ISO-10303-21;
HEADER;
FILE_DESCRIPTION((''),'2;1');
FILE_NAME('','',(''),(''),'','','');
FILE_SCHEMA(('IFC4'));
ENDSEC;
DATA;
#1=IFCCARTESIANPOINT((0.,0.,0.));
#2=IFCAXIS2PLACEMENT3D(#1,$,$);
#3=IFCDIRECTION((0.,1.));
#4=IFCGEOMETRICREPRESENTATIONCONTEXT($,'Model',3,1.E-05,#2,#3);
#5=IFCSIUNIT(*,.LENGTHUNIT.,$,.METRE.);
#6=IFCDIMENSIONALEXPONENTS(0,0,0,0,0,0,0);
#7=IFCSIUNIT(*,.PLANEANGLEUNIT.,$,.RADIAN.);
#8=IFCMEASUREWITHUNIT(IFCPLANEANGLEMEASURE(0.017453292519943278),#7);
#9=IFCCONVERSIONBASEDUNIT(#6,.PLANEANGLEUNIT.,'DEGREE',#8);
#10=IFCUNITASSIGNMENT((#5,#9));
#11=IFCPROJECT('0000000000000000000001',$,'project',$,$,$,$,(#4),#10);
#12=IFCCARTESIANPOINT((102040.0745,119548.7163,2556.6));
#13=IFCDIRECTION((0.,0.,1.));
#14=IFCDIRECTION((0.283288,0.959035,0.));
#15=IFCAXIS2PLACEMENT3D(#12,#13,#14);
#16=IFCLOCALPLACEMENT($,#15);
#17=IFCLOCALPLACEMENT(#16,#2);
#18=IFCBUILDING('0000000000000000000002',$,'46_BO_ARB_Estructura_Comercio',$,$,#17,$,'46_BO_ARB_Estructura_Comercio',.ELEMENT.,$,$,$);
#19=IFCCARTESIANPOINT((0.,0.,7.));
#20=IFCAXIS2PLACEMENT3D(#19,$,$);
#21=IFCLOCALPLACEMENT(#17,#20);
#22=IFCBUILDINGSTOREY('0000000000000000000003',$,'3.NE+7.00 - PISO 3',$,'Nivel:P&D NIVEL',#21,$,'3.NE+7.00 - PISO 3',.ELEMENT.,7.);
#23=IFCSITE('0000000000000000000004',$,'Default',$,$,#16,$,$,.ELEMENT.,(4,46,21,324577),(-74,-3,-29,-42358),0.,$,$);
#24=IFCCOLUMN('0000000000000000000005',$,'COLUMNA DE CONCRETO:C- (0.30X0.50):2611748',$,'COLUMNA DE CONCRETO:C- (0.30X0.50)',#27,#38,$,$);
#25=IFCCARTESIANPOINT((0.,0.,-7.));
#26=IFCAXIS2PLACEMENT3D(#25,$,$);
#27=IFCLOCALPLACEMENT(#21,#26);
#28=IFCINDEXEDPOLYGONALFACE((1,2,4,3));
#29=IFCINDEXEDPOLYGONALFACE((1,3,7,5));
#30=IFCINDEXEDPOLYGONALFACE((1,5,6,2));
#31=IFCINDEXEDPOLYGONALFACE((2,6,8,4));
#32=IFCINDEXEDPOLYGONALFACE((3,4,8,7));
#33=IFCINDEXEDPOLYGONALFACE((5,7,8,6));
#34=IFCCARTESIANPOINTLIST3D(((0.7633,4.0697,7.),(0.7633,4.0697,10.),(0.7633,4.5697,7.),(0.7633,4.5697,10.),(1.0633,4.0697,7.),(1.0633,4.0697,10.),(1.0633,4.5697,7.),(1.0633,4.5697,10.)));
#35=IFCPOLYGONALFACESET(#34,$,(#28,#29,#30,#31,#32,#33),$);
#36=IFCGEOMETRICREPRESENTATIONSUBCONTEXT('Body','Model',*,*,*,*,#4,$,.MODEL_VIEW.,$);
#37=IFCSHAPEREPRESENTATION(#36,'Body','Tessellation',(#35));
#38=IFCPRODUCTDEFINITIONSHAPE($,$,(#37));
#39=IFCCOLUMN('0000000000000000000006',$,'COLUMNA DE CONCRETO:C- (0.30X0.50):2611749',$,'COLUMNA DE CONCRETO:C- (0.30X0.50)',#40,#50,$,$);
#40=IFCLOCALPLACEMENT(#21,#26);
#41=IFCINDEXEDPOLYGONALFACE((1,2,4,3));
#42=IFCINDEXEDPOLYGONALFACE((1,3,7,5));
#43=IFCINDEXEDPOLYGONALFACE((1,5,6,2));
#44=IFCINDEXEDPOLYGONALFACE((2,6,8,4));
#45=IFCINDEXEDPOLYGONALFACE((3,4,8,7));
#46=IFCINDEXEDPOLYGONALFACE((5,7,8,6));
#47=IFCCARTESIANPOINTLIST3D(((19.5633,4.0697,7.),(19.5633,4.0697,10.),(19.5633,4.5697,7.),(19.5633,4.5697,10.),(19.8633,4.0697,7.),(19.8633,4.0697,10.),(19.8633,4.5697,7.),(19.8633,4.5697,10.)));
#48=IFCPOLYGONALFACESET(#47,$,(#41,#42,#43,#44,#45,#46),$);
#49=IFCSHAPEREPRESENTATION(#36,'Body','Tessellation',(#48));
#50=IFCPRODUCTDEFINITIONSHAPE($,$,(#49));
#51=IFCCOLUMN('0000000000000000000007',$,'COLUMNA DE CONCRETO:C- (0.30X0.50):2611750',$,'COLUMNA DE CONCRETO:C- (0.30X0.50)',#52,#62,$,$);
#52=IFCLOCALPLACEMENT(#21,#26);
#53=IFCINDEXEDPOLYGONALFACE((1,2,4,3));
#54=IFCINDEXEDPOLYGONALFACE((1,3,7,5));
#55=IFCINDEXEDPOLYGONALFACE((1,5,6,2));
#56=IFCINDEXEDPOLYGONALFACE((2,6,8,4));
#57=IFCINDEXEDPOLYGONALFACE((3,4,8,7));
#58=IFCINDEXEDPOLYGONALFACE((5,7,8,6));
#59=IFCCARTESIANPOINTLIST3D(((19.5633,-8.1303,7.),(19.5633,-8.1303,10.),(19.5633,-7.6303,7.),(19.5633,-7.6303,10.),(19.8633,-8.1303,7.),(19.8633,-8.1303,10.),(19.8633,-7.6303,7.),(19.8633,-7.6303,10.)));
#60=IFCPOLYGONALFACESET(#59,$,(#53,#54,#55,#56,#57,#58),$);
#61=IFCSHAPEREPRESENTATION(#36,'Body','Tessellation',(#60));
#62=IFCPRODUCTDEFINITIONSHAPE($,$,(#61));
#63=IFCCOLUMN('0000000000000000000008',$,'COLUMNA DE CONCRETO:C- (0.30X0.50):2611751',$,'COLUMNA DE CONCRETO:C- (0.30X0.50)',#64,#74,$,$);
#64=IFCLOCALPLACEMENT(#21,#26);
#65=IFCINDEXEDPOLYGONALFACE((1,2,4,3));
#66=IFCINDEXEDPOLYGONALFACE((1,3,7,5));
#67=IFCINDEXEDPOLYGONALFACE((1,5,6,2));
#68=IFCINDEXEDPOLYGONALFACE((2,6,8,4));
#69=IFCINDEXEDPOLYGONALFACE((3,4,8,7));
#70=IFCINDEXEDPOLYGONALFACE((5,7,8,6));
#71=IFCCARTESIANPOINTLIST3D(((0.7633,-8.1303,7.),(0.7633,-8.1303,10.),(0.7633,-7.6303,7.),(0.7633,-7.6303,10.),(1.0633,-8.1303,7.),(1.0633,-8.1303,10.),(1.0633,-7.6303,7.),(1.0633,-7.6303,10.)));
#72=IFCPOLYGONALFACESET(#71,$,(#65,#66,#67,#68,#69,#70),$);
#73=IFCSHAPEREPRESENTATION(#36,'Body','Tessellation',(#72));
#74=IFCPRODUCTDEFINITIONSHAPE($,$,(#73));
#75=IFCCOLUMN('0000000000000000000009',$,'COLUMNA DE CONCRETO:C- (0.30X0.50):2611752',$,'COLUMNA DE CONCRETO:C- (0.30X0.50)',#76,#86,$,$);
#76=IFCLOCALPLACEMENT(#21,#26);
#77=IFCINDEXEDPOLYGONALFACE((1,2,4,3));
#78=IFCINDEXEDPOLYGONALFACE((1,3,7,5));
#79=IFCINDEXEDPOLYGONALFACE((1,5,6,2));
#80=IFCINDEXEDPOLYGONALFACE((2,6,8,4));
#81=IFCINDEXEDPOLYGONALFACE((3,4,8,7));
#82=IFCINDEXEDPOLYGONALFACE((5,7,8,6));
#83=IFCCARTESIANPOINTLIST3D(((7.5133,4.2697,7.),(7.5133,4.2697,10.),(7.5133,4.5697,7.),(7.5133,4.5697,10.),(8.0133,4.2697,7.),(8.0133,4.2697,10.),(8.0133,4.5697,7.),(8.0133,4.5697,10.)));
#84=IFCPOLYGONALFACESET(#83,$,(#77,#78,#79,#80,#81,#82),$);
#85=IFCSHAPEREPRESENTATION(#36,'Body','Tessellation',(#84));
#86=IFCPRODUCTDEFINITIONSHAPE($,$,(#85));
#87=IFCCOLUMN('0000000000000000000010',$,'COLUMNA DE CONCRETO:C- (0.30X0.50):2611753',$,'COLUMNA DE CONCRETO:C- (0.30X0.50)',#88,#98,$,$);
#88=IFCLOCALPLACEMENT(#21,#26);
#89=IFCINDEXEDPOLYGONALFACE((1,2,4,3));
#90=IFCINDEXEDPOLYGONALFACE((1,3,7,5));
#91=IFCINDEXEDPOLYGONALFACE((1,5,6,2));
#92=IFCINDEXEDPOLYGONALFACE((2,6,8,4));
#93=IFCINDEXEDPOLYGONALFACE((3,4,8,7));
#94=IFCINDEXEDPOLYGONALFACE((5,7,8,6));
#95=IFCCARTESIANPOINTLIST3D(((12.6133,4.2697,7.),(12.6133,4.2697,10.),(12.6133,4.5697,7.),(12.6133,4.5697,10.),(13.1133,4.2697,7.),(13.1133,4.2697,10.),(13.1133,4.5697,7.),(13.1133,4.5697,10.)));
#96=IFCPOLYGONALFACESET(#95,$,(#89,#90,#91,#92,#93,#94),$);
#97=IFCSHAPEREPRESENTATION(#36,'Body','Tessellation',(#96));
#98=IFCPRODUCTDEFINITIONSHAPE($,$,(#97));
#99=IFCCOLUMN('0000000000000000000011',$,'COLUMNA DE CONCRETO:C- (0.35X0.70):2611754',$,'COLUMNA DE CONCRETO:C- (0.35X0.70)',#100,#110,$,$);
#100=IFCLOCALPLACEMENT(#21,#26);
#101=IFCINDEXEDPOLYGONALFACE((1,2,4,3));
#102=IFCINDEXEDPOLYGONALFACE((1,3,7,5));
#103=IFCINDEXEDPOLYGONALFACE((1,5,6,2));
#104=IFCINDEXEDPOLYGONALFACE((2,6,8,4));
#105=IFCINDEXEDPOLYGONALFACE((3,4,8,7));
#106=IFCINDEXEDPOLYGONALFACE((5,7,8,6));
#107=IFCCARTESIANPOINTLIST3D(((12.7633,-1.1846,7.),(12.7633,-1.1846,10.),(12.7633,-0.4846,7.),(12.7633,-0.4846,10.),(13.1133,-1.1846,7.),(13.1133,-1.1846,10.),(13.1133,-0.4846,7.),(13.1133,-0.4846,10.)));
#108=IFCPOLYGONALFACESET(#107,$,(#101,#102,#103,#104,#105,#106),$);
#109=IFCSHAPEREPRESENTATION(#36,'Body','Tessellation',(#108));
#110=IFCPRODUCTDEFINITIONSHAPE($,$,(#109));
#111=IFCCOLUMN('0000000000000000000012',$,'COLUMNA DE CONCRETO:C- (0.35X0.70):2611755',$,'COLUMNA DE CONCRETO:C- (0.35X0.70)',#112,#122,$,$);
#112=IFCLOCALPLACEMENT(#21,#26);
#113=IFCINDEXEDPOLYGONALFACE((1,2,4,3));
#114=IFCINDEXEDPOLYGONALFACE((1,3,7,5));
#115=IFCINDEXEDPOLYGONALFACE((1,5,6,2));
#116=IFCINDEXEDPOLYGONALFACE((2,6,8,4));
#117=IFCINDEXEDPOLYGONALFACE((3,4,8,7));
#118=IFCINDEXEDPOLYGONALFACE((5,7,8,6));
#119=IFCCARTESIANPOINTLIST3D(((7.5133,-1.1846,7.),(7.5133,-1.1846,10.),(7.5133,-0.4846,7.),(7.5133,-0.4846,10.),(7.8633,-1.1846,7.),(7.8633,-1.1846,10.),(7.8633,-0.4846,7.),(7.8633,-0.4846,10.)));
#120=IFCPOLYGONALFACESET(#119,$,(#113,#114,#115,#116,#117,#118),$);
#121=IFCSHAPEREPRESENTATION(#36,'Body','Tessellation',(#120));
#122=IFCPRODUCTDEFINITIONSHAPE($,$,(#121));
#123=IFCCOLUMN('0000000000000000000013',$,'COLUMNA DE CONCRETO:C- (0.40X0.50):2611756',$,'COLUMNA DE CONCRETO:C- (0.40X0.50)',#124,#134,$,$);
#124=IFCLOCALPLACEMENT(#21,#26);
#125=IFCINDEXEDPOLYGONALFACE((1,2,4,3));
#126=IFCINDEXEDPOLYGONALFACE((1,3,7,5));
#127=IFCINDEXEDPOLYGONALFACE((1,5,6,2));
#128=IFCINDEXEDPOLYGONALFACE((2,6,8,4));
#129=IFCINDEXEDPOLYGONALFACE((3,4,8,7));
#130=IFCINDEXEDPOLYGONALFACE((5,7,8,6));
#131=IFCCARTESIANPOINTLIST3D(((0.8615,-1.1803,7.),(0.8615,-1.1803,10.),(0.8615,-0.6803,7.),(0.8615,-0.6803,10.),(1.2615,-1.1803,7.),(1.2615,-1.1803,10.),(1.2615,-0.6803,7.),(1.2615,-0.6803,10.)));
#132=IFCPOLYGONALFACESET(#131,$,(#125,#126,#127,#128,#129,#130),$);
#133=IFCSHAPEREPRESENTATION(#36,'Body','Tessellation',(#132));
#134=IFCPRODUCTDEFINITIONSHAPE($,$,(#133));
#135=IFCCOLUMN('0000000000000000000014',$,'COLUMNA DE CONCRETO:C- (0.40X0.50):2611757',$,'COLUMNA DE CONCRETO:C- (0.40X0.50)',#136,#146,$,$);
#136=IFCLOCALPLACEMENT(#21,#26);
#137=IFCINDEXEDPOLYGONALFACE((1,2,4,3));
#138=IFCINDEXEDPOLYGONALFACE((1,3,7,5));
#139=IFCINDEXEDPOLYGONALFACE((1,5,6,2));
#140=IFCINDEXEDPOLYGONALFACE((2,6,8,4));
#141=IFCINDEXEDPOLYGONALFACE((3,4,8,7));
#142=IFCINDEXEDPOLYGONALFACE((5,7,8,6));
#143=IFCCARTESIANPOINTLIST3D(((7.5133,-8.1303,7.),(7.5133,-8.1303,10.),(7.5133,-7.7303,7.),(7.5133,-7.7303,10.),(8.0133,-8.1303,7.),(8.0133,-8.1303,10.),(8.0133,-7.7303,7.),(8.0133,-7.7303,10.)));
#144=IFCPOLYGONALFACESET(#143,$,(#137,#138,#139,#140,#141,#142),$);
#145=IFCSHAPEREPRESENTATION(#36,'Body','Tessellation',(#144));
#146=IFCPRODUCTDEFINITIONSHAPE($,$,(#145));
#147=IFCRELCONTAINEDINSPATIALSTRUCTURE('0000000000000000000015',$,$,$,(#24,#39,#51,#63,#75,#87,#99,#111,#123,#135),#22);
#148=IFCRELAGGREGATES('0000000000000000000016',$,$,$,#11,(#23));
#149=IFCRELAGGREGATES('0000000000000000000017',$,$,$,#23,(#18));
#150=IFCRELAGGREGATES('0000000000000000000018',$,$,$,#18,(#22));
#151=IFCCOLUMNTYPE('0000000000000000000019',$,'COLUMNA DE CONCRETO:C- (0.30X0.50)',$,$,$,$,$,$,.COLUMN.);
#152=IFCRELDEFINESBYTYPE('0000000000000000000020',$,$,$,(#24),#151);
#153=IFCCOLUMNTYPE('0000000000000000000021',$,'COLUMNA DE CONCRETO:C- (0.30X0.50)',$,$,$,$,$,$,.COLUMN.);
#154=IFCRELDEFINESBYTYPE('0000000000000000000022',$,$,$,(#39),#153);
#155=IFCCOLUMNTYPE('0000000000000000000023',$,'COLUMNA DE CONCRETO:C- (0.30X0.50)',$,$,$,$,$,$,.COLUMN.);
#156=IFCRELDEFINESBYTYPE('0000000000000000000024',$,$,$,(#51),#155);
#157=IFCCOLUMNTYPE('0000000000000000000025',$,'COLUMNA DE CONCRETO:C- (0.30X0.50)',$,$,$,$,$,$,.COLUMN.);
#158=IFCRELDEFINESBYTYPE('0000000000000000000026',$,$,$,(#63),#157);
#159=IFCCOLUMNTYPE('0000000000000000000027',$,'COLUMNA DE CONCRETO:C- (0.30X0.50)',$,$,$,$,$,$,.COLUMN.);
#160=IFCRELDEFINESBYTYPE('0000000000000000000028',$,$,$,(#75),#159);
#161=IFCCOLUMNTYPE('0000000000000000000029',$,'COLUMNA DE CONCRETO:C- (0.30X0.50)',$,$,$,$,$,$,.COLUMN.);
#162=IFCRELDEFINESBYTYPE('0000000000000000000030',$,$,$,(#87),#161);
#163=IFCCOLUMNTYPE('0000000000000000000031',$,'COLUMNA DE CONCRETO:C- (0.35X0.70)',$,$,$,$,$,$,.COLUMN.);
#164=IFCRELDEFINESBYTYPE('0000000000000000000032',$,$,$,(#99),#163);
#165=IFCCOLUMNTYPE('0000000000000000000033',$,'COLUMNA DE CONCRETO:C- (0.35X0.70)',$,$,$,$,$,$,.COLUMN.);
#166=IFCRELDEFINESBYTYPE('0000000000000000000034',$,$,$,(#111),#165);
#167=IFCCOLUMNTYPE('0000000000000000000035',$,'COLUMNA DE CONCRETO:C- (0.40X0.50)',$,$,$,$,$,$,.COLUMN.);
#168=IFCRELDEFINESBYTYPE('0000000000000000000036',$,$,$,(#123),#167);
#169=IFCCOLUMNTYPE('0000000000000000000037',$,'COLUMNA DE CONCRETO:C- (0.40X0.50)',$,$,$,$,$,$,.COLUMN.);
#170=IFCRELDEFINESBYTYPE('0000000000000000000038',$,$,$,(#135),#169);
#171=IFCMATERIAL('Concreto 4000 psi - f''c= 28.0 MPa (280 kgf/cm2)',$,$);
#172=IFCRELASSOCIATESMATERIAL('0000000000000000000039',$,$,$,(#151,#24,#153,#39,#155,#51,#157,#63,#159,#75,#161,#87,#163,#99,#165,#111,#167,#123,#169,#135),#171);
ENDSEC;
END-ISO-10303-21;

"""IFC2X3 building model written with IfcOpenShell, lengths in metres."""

from ifc_helpers import new_model, entity, si_unit, converted_unit, direction, frame, frame_2d, origin, origin_2d_with_axis, place, context, subcontext, project, spatial, rectangle, extrude, source, transform, mapped, material, type_object, type_shapes, element, save


model = new_model("IFC2X3")

# Units and contexts
model_context = context("Model", 3, precision=1e-05, world=origin(), true_north=direction((0.0, 1.0)))
body_context = subcontext(model_context, "Body", "Model", "MODEL_VIEW")
ifc_project = project(units=[si_unit("LENGTHUNIT", "METRE"), converted_unit("PLANEANGLEUNIT", "DEGREE", entity("IfcPlaneAngleMeasure", 0.017453292519943278), si_unit("PLANEANGLEUNIT", "RADIAN"), dimensions=[0, 0, 0, 0, 0, 0, 0])], contexts=[model_context])

# Site, building, storey
site_placement = place(None, frame((102040.0745, 119548.7163, 2556.6), z_axis=(0.0, 0.0, 1.0), x_axis=(0.283288, 0.959035, 0.0)))
site = spatial("IfcSite", under=ifc_project, at=site_placement, Name="Default", CompositionType="ELEMENT", RefLatitude=(4, 46, 21, 324577), RefLongitude=(-74, -3, -29, -42358), RefElevation=0.0)
building_placement = place(site_placement, origin())
building = spatial("IfcBuilding", under=site, at=building_placement, Name="46_BO_ARB_Estructura_Comercio", LongName="46_BO_ARB_Estructura_Comercio", CompositionType="ELEMENT")
storey_placement = place(building_placement, frame((0.0, 0.0, 7.0)))
storey = spatial("IfcBuildingStorey", under=building, at=storey_placement, Name="3.NE+7.00 - PISO 3", ObjectType="Nivel:P&D NIVEL", LongName="3.NE+7.00 - PISO 3", CompositionType="ELEMENT", Elevation=7.0)

# Columns
ifc_material_1 = material(Name="Concreto 4000 psi - f'c= 28.0 MPa (280 kgf/cm2)")
column_type_1 = type_object("IfcColumnType", Name="COLUMNA DE CONCRETO:C- (0.30X0.50)", PredefinedType="COLUMN", material=ifc_material_1)
shared_shape_1 = source(origin(), body_context, "Body", "SweptSolid", [
    extrude(rectangle(XDim=0.3, YDim=0.5, at=frame_2d((0.0, 0.0), x_axis=(1.0, 0.0))), frame((0.9133, 4.3197, 7.0), z_axis=(0.0, 0.0, 1.0), x_axis=(-1.0, 0.0, 0.0)), (0.0, 0.0, 1.0), 3.0),
])
type_shapes(column_type_1, [shared_shape_1])
column_1_placement = place(storey_placement, frame((0.0, 0.0, -7.0)))
element("IfcColumn", 1, at=column_1_placement, inside=storey, type_object=column_type_1, material=ifc_material_1, Name="COLUMNA DE CONCRETO:C- (0.30X0.50):2611748", ObjectType="COLUMNA DE CONCRETO:C- (0.30X0.50)", context=body_context, shape_type="MappedRepresentation", body=[
    mapped(shared_shape_1, transform((0.0, 0.0, 0.0), scale=1.0)),
])
column_type_2 = type_object("IfcColumnType", Name="COLUMNA DE CONCRETO:C- (0.30X0.50)", PredefinedType="COLUMN", material=ifc_material_1)
shared_shape_2 = source(origin(), body_context, "Body", "SweptSolid", [
    extrude(rectangle(XDim=0.3, YDim=0.5, at=origin_2d_with_axis()), frame((19.7133, 4.3197, 7.0), z_axis=(0.0, 0.0, 1.0), x_axis=(-1.0, 0.0, 0.0)), (0.0, 0.0, 1.0), 3.0),
])
type_shapes(column_type_2, [shared_shape_2])
column_2_placement = place(storey_placement, frame((0.0, 0.0, -7.0)))
element("IfcColumn", 2, at=column_2_placement, inside=storey, type_object=column_type_2, material=ifc_material_1, Name="COLUMNA DE CONCRETO:C- (0.30X0.50):2611749", ObjectType="COLUMNA DE CONCRETO:C- (0.30X0.50)", context=body_context, shape_type="MappedRepresentation", body=[
    mapped(shared_shape_2, transform((0.0, 0.0, 0.0), scale=1.0)),
])
column_type_3 = type_object("IfcColumnType", Name="COLUMNA DE CONCRETO:C- (0.30X0.50)", PredefinedType="COLUMN", material=ifc_material_1)
shared_shape_3 = source(origin(), body_context, "Body", "SweptSolid", [
    extrude(rectangle(XDim=0.3, YDim=0.5, at=frame_2d((0.0, 0.0), x_axis=(1.0, 0.0))), frame((19.7133, -7.8803, 7.0), z_axis=(0.0, 0.0, 1.0), x_axis=(-1.0, 0.0, 0.0)), (0.0, 0.0, 1.0), 3.0),
])
type_shapes(column_type_3, [shared_shape_3])
column_3_placement = place(storey_placement, frame((0.0, 0.0, -7.0)))
element("IfcColumn", 3, at=column_3_placement, inside=storey, type_object=column_type_3, material=ifc_material_1, Name="COLUMNA DE CONCRETO:C- (0.30X0.50):2611750", ObjectType="COLUMNA DE CONCRETO:C- (0.30X0.50)", context=body_context, shape_type="MappedRepresentation", body=[
    mapped(shared_shape_3, transform((0.0, 0.0, 0.0), scale=1.0)),
])
column_type_4 = type_object("IfcColumnType", Name="COLUMNA DE CONCRETO:C- (0.30X0.50)", PredefinedType="COLUMN", material=ifc_material_1)
shared_shape_4 = source(origin(), body_context, "Body", "SweptSolid", [
    extrude(rectangle(XDim=0.3, YDim=0.5, at=frame_2d((0.0, 0.0), x_axis=(1.0, 0.0))), frame((0.9133, -7.8803, 7.0), z_axis=(0.0, 0.0, 1.0), x_axis=(-1.0, 0.0, 0.0)), (0.0, 0.0, 1.0), 3.0),
])
type_shapes(column_type_4, [shared_shape_4])
column_4_placement = place(storey_placement, frame((0.0, 0.0, -7.0)))
element("IfcColumn", 4, at=column_4_placement, inside=storey, type_object=column_type_4, material=ifc_material_1, Name="COLUMNA DE CONCRETO:C- (0.30X0.50):2611751", ObjectType="COLUMNA DE CONCRETO:C- (0.30X0.50)", context=body_context, shape_type="MappedRepresentation", body=[
    mapped(shared_shape_4, transform((0.0, 0.0, 0.0), scale=1.0)),
])
column_type_5 = type_object("IfcColumnType", Name="COLUMNA DE CONCRETO:C- (0.30X0.50)", PredefinedType="COLUMN", material=ifc_material_1)
shared_shape_5 = source(origin(), body_context, "Body", "SweptSolid", [
    extrude(rectangle(XDim=0.3, YDim=0.5, at=frame_2d((0.0, 0.0), x_axis=(1.0, 0.0))), frame((7.7633, 4.4197, 7.0), z_axis=(0.0, 0.0, 1.0), x_axis=(0.0, -1.0, 0.0)), (0.0, 0.0, 1.0), 3.0),
])
type_shapes(column_type_5, [shared_shape_5])
column_5_placement = place(storey_placement, frame((0.0, 0.0, -7.0)))
element("IfcColumn", 5, at=column_5_placement, inside=storey, type_object=column_type_5, material=ifc_material_1, Name="COLUMNA DE CONCRETO:C- (0.30X0.50):2611752", ObjectType="COLUMNA DE CONCRETO:C- (0.30X0.50)", context=body_context, shape_type="MappedRepresentation", body=[
    mapped(shared_shape_5, transform((0.0, 0.0, 0.0), scale=1.0)),
])
column_type_6 = type_object("IfcColumnType", Name="COLUMNA DE CONCRETO:C- (0.30X0.50)", PredefinedType="COLUMN", material=ifc_material_1)
shared_shape_6 = source(origin(), body_context, "Body", "SweptSolid", [
    extrude(rectangle(XDim=0.3, YDim=0.5, at=frame_2d((0.0, 0.0), x_axis=(1.0, 0.0))), frame((12.8633, 4.4197, 7.0), z_axis=(0.0, 0.0, 1.0), x_axis=(0.0, -1.0, 0.0)), (0.0, 0.0, 1.0), 3.0),
])
type_shapes(column_type_6, [shared_shape_6])
column_6_placement = place(storey_placement, frame((0.0, 0.0, -7.0)))
element("IfcColumn", 6, at=column_6_placement, inside=storey, type_object=column_type_6, material=ifc_material_1, Name="COLUMNA DE CONCRETO:C- (0.30X0.50):2611753", ObjectType="COLUMNA DE CONCRETO:C- (0.30X0.50)", context=body_context, shape_type="MappedRepresentation", body=[
    mapped(shared_shape_6, transform((0.0, 0.0, 0.0), scale=1.0)),
])
column_type_7 = type_object("IfcColumnType", Name="COLUMNA DE CONCRETO:C- (0.35X0.70)", PredefinedType="COLUMN", material=ifc_material_1)
shared_shape_7 = source(origin(), body_context, "Body", "SweptSolid", [
    extrude(rectangle(XDim=0.35, YDim=0.7, at=frame_2d((0.0, 0.0), x_axis=(1.0, 0.0))), frame((12.9383, -0.8346, 7.0)), (0.0, 0.0, 1.0), 3.0),
])
type_shapes(column_type_7, [shared_shape_7])
column_7_placement = place(storey_placement, frame((0.0, 0.0, -7.0)))
element("IfcColumn", 7, at=column_7_placement, inside=storey, type_object=column_type_7, material=ifc_material_1, Name="COLUMNA DE CONCRETO:C- (0.35X0.70):2611754", ObjectType="COLUMNA DE CONCRETO:C- (0.35X0.70)", context=body_context, shape_type="MappedRepresentation", body=[
    mapped(shared_shape_7, transform((0.0, 0.0, 0.0), scale=1.0)),
])
column_type_8 = type_object("IfcColumnType", Name="COLUMNA DE CONCRETO:C- (0.35X0.70)", PredefinedType="COLUMN", material=ifc_material_1)
shared_shape_8 = source(origin(), body_context, "Body", "SweptSolid", [
    extrude(rectangle(XDim=0.7, YDim=0.35, at=frame_2d((0.0, 0.0), x_axis=(1.0, 0.0))), frame((7.6883, -0.8346, 7.0), z_axis=(0.0, 0.0, 1.0), x_axis=(0.0, 1.0, 0.0)), (0.0, 0.0, 1.0), 3.0),
])
type_shapes(column_type_8, [shared_shape_8])
column_8_placement = place(storey_placement, frame((0.0, 0.0, -7.0)))
element("IfcColumn", 8, at=column_8_placement, inside=storey, type_object=column_type_8, material=ifc_material_1, Name="COLUMNA DE CONCRETO:C- (0.35X0.70):2611755", ObjectType="COLUMNA DE CONCRETO:C- (0.35X0.70)", context=body_context, shape_type="MappedRepresentation", body=[
    mapped(shared_shape_8, transform((0.0, 0.0, 0.0), scale=1.0)),
])
column_type_9 = type_object("IfcColumnType", Name="COLUMNA DE CONCRETO:C- (0.40X0.50)", PredefinedType="COLUMN", material=ifc_material_1)
shared_shape_9 = source(origin(), body_context, "Body", "SweptSolid", [
    extrude(rectangle(XDim=0.4, YDim=0.5, at=frame_2d((0.0, 0.0), x_axis=(1.0, 0.0))), frame((1.0615, -0.9303, 7.0), z_axis=(0.0, 0.0, 1.0), x_axis=(-1.0, 0.0, 0.0)), (0.0, 0.0, 1.0), 3.0),
])
type_shapes(column_type_9, [shared_shape_9])
column_9_placement = place(storey_placement, frame((0.0, 0.0, -7.0)))
element("IfcColumn", 9, at=column_9_placement, inside=storey, type_object=column_type_9, material=ifc_material_1, Name="COLUMNA DE CONCRETO:C- (0.40X0.50):2611756", ObjectType="COLUMNA DE CONCRETO:C- (0.40X0.50)", context=body_context, shape_type="MappedRepresentation", body=[
    mapped(shared_shape_9, transform((0.0, 0.0, 0.0), scale=1.0)),
])
column_type_10 = type_object("IfcColumnType", Name="COLUMNA DE CONCRETO:C- (0.40X0.50)", PredefinedType="COLUMN", material=ifc_material_1)
shared_shape_10 = source(origin(), body_context, "Body", "SweptSolid", [
    extrude(rectangle(XDim=0.4, YDim=0.5, at=frame_2d((0.0, 0.0), x_axis=(1.0, 0.0))), frame((7.7633, -7.9303, 7.0), z_axis=(0.0, 0.0, 1.0), x_axis=(0.0, -1.0, 0.0)), (0.0, 0.0, 1.0), 3.0),
])
type_shapes(column_type_10, [shared_shape_10])
column_10_placement = place(storey_placement, frame((0.0, 0.0, -7.0)))
element("IfcColumn", 10, at=column_10_placement, inside=storey, type_object=column_type_10, material=ifc_material_1, Name="COLUMNA DE CONCRETO:C- (0.40X0.50):2611757", ObjectType="COLUMNA DE CONCRETO:C- (0.40X0.50)", context=body_context, shape_type="MappedRepresentation", body=[
    mapped(shared_shape_10, transform((0.0, 0.0, 0.0), scale=1.0)),
])

save(model, "model.ifc")
